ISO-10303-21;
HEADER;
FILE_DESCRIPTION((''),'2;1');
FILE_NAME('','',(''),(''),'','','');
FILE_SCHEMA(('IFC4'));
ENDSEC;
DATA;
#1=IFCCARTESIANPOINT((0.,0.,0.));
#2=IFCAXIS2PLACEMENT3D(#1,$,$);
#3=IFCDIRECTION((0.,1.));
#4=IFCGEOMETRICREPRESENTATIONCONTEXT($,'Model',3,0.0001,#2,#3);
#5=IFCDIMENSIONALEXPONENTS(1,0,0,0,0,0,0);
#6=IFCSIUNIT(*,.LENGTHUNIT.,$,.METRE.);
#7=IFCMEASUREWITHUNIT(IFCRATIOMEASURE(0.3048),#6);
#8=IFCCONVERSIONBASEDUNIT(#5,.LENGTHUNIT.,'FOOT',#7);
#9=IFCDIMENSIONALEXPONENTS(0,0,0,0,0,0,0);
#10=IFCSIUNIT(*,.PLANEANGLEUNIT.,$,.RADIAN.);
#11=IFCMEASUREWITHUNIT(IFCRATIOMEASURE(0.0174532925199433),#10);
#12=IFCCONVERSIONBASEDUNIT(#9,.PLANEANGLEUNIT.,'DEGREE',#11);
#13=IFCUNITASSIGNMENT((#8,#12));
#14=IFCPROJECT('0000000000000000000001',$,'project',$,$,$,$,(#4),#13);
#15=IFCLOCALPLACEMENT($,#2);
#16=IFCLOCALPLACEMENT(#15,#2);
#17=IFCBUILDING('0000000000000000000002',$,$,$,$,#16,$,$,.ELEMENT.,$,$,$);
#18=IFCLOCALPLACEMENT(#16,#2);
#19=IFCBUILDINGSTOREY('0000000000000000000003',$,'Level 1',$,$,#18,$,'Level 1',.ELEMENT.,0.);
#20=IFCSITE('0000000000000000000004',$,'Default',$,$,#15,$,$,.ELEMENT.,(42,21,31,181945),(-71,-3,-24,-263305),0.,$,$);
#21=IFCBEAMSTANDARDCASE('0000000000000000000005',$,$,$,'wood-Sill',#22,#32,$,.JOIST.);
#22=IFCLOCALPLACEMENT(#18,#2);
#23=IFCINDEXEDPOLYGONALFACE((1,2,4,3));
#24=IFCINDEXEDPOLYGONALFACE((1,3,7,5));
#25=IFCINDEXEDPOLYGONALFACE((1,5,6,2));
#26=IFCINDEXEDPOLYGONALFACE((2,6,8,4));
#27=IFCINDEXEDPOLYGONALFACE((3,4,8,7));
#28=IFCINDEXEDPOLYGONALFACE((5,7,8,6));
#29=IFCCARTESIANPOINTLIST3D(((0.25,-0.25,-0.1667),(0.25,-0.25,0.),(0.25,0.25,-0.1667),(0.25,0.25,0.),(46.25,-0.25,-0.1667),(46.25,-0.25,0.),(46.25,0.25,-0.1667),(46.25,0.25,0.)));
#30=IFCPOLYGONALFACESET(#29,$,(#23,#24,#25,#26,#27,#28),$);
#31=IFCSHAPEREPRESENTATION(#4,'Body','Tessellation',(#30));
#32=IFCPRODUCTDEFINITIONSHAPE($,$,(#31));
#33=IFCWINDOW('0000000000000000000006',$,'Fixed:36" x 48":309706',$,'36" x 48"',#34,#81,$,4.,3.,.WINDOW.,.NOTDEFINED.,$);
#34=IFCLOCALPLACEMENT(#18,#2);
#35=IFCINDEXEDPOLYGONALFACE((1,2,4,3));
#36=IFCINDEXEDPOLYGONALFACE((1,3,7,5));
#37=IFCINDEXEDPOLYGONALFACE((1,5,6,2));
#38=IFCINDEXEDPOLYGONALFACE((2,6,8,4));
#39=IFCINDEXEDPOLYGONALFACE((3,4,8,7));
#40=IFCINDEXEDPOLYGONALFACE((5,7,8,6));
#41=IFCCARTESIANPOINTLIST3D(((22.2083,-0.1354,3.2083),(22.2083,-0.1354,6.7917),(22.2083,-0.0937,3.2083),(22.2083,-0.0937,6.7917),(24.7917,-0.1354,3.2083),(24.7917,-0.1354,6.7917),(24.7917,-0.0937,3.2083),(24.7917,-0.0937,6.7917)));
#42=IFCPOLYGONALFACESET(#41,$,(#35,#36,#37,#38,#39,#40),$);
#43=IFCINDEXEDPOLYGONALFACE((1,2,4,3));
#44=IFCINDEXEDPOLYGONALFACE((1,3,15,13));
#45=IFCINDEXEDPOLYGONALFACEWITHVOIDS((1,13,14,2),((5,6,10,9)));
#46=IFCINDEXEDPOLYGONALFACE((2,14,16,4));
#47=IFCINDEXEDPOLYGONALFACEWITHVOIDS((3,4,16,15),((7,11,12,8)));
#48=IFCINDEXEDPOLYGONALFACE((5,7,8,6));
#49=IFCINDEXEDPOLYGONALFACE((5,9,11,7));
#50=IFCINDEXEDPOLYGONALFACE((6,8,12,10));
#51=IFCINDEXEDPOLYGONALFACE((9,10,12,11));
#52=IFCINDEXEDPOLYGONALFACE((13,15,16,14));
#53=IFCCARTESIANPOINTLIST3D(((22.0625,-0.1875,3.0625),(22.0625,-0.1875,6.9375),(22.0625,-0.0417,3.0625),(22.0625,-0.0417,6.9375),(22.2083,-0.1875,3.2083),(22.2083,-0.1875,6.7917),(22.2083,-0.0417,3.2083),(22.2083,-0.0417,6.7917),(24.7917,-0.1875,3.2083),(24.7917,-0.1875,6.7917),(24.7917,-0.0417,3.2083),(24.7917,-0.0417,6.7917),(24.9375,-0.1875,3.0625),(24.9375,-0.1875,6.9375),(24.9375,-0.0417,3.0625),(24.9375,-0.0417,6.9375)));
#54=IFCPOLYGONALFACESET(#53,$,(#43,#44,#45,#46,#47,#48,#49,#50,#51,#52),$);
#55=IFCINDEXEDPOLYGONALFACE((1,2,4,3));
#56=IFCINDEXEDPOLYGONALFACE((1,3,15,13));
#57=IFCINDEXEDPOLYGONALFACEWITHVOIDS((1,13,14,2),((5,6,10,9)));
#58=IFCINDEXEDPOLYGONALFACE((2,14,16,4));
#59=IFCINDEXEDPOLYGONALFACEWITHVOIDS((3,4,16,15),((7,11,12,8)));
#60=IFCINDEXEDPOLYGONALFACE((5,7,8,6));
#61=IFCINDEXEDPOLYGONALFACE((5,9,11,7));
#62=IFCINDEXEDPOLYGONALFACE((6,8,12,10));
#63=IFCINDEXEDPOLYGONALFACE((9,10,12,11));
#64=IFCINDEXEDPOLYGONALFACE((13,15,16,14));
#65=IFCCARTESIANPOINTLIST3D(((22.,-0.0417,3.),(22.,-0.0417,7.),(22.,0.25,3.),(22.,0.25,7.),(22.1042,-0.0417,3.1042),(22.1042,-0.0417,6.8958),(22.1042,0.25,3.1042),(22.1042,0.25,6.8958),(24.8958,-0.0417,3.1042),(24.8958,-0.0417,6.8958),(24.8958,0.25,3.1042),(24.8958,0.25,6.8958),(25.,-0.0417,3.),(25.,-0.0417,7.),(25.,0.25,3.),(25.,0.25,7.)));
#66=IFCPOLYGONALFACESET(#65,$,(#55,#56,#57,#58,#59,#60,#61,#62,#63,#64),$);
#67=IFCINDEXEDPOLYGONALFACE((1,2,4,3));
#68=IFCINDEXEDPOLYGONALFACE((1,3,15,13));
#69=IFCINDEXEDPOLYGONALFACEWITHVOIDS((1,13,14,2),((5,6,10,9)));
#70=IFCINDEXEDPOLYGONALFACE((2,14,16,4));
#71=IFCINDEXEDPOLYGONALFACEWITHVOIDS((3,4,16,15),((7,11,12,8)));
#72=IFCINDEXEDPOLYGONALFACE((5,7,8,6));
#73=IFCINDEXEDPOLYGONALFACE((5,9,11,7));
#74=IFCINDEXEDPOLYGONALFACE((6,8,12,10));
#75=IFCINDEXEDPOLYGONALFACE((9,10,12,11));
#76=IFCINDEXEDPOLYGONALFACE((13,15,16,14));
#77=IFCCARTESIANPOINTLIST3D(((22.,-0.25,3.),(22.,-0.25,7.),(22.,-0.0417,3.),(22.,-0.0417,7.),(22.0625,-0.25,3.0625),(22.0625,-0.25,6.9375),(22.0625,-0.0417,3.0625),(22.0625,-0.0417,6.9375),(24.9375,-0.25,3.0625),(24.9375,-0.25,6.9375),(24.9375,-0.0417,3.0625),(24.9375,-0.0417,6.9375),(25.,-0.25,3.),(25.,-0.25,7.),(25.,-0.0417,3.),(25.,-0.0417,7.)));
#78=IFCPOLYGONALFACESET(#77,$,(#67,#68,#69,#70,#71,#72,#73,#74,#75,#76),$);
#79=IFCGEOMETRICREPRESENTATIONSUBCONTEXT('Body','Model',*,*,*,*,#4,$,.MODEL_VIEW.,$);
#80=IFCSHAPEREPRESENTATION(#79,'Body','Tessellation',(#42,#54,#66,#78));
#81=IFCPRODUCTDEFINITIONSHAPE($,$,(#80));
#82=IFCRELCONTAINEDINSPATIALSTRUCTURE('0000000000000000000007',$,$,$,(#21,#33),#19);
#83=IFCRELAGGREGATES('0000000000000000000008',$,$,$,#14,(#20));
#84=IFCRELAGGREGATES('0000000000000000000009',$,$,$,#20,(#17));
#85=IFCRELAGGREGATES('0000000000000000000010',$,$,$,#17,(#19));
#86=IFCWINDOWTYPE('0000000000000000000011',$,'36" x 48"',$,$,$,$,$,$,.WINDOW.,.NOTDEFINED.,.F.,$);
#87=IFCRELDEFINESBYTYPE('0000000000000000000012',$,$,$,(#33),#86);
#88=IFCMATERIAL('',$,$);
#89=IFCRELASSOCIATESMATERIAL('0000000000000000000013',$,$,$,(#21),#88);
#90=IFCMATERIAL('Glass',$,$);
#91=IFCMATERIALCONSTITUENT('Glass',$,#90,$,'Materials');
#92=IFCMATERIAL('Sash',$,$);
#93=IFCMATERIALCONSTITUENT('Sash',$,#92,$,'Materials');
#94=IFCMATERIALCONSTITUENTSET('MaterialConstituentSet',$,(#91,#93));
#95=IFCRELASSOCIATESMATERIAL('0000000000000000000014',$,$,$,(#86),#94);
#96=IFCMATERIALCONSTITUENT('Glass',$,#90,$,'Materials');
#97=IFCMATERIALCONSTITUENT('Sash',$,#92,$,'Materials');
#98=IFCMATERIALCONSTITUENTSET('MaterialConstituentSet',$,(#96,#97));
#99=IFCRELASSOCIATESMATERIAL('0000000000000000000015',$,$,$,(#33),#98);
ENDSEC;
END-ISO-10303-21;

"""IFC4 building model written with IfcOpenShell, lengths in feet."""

from ifc_helpers import new_model, entity, si_unit, converted_unit, direction, frame, frame_2d, origin, place, context, subcontext, project, spatial, polyline, rectangle, outline, extrude, source, transform, mapped, material, constituent, constituent_set, type_object, type_shapes, element, save


model = new_model("IFC4")

# Units and contexts
model_context = context("Model", 3, precision=0.0001, world=origin(), true_north=direction((0.0, 1.0)))
body_context = subcontext(model_context, "Body", "Model", "MODEL_VIEW")
ifc_project = project(units=[converted_unit("LENGTHUNIT", "FOOT", entity("IfcRatioMeasure", 0.3048), si_unit("LENGTHUNIT", "METRE"), dimensions=[1, 0, 0, 0, 0, 0, 0]), converted_unit("PLANEANGLEUNIT", "DEGREE", entity("IfcRatioMeasure", 0.0174532925199433), si_unit("PLANEANGLEUNIT", "RADIAN"), dimensions=[0, 0, 0, 0, 0, 0, 0])], contexts=[model_context])

# Site, building, storey
site_placement = place(None, origin())
site = spatial("IfcSite", under=ifc_project, at=site_placement, Name="Default", CompositionType="ELEMENT", RefLatitude=(42, 21, 31, 181945), RefLongitude=(-71, -3, -24, -263305), RefElevation=0.0)
building_placement = place(site_placement, origin())
building = spatial("IfcBuilding", under=site, at=building_placement, CompositionType="ELEMENT")
storey_placement = place(building_placement, origin())
storey = spatial("IfcBuildingStorey", under=building, at=storey_placement, Name="Level 1", LongName="Level 1", CompositionType="ELEMENT", Elevation=0.0)

# Shared definitions
placement_1 = place(storey_placement, frame((46.25, 0.0, 0.0), z_axis=(0.0, 0.0, 1.0), x_axis=(-1.0, 0.0, 0.0)))

# Beam
ifc_material_1 = material(Name="")
beam_1_placement = place(placement_1, frame((23.0, 0.0, -0.1667), z_axis=(0.0, 0.0, 1.0), x_axis=(-1.0, 0.0, 0.0)))
element("IfcBeamStandardCase", 1, at=beam_1_placement, inside=storey, material=ifc_material_1, ObjectType="wood-Sill", PredefinedType="JOIST", context=model_context, shape_type="SweptSolid", body=[
    extrude(rectangle(XDim=46.0, YDim=0.5), origin(), (0.0, 0.0, 1.0), 0.1667),
])

# Window
ifc_material_2 = material(Name="Glass")
ifc_constituent_1 = constituent(ifc_material_2, Name="Glass", Category="Materials")
ifc_material_3 = material(Name="Sash")
ifc_constituent_2 = constituent(ifc_material_3, Name="Sash", Category="Materials")
ifc_constituent_set_1 = constituent_set(constituents=[ifc_constituent_1, ifc_constituent_2], Name="MaterialConstituentSet")
ifc_constituent_3 = constituent(ifc_material_2, Name="Glass", Category="Materials")
ifc_constituent_4 = constituent(ifc_material_3, Name="Sash", Category="Materials")
ifc_constituent_set_2 = constituent_set(constituents=[ifc_constituent_3, ifc_constituent_4], Name="MaterialConstituentSet")
window_type = type_object("IfcWindowType", Name="36\" x 48\"", ParameterTakesPrecedence=False, PartitioningType="NOTDEFINED", PredefinedType="WINDOW", material=ifc_constituent_set_2)
shared_shape = source(origin(), body_context, "Body", "SweptSolid", [
    extrude(rectangle(XDim=0.0417, YDim=2.5833, at=frame_2d((0.0, 0.0), x_axis=(1.0, 0.0))), frame((1.5, 0.3646, 0.2083), z_axis=(0.0, 0.0, 1.0), x_axis=(0.0, 1.0, 0.0)), (0.0, 0.0, 1.0), 3.5833),
    extrude(outline(polyline([(-1.4375, -1.9375), (1.4375, -1.9375), (1.4375, 1.9375), (-1.4375, 1.9375), (-1.4375, -1.9375)]), holes=[polyline([(-1.2917, -1.7917), (-1.2917, 1.7917), (1.2917, 1.7917), (1.2917, -1.7917), (-1.2917, -1.7917)])]), frame((1.5, 0.2917, 2.0), z_axis=(0.0, 1.0, 0.0), x_axis=(1.0, 0.0, 0.0)), (0.0, 0.0, 1.0), 0.1458),
    extrude(outline(polyline([(-1.5, -2.0), (1.5, -2.0), (1.5, 2.0), (-1.5, 2.0), (-1.5, -2.0)]), holes=[polyline([(-1.3958, -1.8958), (-1.3958, 1.8958), (1.3958, 1.8958), (1.3958, -1.8958), (-1.3958, -1.8958)])]), frame((1.5, 0.0, 2.0), z_axis=(0.0, 1.0, 0.0), x_axis=(1.0, 0.0, 0.0)), (0.0, 0.0, 1.0), 0.2917),
    extrude(outline(polyline([(-2.0, -1.5), (2.0, -1.5), (2.0, 1.5), (-2.0, 1.5), (-2.0, -1.5)]), holes=[polyline([(-1.9375, -1.4375), (-1.9375, 1.4375), (1.9375, 1.4375), (1.9375, -1.4375), (-1.9375, -1.4375)])]), frame((1.5, 0.2917, 2.0), z_axis=(0.0, 1.0, 0.0), x_axis=(0.0, 0.0, -1.0)), (0.0, 0.0, 1.0), 0.2083),
])
type_shapes(window_type, [shared_shape])
placement_2 = place(placement_1, frame((21.25, -0.25, 3.0)))
window_placement = place(placement_2, origin())
element("IfcWindow", 2, at=window_placement, inside=storey, type_object=window_type, material=ifc_constituent_set_1, Name="Fixed:36\" x 48\":309706", ObjectType="36\" x 48\"", OverallHeight=4.0, OverallWidth=3.0, PartitioningType="NOTDEFINED", PredefinedType="WINDOW", context=body_context, shape_type="MappedRepresentation", body=[
    mapped(shared_shape, transform((0.0, 0.0, 0.0), scale=1.0)),
])

save(model, "model.ifc")
